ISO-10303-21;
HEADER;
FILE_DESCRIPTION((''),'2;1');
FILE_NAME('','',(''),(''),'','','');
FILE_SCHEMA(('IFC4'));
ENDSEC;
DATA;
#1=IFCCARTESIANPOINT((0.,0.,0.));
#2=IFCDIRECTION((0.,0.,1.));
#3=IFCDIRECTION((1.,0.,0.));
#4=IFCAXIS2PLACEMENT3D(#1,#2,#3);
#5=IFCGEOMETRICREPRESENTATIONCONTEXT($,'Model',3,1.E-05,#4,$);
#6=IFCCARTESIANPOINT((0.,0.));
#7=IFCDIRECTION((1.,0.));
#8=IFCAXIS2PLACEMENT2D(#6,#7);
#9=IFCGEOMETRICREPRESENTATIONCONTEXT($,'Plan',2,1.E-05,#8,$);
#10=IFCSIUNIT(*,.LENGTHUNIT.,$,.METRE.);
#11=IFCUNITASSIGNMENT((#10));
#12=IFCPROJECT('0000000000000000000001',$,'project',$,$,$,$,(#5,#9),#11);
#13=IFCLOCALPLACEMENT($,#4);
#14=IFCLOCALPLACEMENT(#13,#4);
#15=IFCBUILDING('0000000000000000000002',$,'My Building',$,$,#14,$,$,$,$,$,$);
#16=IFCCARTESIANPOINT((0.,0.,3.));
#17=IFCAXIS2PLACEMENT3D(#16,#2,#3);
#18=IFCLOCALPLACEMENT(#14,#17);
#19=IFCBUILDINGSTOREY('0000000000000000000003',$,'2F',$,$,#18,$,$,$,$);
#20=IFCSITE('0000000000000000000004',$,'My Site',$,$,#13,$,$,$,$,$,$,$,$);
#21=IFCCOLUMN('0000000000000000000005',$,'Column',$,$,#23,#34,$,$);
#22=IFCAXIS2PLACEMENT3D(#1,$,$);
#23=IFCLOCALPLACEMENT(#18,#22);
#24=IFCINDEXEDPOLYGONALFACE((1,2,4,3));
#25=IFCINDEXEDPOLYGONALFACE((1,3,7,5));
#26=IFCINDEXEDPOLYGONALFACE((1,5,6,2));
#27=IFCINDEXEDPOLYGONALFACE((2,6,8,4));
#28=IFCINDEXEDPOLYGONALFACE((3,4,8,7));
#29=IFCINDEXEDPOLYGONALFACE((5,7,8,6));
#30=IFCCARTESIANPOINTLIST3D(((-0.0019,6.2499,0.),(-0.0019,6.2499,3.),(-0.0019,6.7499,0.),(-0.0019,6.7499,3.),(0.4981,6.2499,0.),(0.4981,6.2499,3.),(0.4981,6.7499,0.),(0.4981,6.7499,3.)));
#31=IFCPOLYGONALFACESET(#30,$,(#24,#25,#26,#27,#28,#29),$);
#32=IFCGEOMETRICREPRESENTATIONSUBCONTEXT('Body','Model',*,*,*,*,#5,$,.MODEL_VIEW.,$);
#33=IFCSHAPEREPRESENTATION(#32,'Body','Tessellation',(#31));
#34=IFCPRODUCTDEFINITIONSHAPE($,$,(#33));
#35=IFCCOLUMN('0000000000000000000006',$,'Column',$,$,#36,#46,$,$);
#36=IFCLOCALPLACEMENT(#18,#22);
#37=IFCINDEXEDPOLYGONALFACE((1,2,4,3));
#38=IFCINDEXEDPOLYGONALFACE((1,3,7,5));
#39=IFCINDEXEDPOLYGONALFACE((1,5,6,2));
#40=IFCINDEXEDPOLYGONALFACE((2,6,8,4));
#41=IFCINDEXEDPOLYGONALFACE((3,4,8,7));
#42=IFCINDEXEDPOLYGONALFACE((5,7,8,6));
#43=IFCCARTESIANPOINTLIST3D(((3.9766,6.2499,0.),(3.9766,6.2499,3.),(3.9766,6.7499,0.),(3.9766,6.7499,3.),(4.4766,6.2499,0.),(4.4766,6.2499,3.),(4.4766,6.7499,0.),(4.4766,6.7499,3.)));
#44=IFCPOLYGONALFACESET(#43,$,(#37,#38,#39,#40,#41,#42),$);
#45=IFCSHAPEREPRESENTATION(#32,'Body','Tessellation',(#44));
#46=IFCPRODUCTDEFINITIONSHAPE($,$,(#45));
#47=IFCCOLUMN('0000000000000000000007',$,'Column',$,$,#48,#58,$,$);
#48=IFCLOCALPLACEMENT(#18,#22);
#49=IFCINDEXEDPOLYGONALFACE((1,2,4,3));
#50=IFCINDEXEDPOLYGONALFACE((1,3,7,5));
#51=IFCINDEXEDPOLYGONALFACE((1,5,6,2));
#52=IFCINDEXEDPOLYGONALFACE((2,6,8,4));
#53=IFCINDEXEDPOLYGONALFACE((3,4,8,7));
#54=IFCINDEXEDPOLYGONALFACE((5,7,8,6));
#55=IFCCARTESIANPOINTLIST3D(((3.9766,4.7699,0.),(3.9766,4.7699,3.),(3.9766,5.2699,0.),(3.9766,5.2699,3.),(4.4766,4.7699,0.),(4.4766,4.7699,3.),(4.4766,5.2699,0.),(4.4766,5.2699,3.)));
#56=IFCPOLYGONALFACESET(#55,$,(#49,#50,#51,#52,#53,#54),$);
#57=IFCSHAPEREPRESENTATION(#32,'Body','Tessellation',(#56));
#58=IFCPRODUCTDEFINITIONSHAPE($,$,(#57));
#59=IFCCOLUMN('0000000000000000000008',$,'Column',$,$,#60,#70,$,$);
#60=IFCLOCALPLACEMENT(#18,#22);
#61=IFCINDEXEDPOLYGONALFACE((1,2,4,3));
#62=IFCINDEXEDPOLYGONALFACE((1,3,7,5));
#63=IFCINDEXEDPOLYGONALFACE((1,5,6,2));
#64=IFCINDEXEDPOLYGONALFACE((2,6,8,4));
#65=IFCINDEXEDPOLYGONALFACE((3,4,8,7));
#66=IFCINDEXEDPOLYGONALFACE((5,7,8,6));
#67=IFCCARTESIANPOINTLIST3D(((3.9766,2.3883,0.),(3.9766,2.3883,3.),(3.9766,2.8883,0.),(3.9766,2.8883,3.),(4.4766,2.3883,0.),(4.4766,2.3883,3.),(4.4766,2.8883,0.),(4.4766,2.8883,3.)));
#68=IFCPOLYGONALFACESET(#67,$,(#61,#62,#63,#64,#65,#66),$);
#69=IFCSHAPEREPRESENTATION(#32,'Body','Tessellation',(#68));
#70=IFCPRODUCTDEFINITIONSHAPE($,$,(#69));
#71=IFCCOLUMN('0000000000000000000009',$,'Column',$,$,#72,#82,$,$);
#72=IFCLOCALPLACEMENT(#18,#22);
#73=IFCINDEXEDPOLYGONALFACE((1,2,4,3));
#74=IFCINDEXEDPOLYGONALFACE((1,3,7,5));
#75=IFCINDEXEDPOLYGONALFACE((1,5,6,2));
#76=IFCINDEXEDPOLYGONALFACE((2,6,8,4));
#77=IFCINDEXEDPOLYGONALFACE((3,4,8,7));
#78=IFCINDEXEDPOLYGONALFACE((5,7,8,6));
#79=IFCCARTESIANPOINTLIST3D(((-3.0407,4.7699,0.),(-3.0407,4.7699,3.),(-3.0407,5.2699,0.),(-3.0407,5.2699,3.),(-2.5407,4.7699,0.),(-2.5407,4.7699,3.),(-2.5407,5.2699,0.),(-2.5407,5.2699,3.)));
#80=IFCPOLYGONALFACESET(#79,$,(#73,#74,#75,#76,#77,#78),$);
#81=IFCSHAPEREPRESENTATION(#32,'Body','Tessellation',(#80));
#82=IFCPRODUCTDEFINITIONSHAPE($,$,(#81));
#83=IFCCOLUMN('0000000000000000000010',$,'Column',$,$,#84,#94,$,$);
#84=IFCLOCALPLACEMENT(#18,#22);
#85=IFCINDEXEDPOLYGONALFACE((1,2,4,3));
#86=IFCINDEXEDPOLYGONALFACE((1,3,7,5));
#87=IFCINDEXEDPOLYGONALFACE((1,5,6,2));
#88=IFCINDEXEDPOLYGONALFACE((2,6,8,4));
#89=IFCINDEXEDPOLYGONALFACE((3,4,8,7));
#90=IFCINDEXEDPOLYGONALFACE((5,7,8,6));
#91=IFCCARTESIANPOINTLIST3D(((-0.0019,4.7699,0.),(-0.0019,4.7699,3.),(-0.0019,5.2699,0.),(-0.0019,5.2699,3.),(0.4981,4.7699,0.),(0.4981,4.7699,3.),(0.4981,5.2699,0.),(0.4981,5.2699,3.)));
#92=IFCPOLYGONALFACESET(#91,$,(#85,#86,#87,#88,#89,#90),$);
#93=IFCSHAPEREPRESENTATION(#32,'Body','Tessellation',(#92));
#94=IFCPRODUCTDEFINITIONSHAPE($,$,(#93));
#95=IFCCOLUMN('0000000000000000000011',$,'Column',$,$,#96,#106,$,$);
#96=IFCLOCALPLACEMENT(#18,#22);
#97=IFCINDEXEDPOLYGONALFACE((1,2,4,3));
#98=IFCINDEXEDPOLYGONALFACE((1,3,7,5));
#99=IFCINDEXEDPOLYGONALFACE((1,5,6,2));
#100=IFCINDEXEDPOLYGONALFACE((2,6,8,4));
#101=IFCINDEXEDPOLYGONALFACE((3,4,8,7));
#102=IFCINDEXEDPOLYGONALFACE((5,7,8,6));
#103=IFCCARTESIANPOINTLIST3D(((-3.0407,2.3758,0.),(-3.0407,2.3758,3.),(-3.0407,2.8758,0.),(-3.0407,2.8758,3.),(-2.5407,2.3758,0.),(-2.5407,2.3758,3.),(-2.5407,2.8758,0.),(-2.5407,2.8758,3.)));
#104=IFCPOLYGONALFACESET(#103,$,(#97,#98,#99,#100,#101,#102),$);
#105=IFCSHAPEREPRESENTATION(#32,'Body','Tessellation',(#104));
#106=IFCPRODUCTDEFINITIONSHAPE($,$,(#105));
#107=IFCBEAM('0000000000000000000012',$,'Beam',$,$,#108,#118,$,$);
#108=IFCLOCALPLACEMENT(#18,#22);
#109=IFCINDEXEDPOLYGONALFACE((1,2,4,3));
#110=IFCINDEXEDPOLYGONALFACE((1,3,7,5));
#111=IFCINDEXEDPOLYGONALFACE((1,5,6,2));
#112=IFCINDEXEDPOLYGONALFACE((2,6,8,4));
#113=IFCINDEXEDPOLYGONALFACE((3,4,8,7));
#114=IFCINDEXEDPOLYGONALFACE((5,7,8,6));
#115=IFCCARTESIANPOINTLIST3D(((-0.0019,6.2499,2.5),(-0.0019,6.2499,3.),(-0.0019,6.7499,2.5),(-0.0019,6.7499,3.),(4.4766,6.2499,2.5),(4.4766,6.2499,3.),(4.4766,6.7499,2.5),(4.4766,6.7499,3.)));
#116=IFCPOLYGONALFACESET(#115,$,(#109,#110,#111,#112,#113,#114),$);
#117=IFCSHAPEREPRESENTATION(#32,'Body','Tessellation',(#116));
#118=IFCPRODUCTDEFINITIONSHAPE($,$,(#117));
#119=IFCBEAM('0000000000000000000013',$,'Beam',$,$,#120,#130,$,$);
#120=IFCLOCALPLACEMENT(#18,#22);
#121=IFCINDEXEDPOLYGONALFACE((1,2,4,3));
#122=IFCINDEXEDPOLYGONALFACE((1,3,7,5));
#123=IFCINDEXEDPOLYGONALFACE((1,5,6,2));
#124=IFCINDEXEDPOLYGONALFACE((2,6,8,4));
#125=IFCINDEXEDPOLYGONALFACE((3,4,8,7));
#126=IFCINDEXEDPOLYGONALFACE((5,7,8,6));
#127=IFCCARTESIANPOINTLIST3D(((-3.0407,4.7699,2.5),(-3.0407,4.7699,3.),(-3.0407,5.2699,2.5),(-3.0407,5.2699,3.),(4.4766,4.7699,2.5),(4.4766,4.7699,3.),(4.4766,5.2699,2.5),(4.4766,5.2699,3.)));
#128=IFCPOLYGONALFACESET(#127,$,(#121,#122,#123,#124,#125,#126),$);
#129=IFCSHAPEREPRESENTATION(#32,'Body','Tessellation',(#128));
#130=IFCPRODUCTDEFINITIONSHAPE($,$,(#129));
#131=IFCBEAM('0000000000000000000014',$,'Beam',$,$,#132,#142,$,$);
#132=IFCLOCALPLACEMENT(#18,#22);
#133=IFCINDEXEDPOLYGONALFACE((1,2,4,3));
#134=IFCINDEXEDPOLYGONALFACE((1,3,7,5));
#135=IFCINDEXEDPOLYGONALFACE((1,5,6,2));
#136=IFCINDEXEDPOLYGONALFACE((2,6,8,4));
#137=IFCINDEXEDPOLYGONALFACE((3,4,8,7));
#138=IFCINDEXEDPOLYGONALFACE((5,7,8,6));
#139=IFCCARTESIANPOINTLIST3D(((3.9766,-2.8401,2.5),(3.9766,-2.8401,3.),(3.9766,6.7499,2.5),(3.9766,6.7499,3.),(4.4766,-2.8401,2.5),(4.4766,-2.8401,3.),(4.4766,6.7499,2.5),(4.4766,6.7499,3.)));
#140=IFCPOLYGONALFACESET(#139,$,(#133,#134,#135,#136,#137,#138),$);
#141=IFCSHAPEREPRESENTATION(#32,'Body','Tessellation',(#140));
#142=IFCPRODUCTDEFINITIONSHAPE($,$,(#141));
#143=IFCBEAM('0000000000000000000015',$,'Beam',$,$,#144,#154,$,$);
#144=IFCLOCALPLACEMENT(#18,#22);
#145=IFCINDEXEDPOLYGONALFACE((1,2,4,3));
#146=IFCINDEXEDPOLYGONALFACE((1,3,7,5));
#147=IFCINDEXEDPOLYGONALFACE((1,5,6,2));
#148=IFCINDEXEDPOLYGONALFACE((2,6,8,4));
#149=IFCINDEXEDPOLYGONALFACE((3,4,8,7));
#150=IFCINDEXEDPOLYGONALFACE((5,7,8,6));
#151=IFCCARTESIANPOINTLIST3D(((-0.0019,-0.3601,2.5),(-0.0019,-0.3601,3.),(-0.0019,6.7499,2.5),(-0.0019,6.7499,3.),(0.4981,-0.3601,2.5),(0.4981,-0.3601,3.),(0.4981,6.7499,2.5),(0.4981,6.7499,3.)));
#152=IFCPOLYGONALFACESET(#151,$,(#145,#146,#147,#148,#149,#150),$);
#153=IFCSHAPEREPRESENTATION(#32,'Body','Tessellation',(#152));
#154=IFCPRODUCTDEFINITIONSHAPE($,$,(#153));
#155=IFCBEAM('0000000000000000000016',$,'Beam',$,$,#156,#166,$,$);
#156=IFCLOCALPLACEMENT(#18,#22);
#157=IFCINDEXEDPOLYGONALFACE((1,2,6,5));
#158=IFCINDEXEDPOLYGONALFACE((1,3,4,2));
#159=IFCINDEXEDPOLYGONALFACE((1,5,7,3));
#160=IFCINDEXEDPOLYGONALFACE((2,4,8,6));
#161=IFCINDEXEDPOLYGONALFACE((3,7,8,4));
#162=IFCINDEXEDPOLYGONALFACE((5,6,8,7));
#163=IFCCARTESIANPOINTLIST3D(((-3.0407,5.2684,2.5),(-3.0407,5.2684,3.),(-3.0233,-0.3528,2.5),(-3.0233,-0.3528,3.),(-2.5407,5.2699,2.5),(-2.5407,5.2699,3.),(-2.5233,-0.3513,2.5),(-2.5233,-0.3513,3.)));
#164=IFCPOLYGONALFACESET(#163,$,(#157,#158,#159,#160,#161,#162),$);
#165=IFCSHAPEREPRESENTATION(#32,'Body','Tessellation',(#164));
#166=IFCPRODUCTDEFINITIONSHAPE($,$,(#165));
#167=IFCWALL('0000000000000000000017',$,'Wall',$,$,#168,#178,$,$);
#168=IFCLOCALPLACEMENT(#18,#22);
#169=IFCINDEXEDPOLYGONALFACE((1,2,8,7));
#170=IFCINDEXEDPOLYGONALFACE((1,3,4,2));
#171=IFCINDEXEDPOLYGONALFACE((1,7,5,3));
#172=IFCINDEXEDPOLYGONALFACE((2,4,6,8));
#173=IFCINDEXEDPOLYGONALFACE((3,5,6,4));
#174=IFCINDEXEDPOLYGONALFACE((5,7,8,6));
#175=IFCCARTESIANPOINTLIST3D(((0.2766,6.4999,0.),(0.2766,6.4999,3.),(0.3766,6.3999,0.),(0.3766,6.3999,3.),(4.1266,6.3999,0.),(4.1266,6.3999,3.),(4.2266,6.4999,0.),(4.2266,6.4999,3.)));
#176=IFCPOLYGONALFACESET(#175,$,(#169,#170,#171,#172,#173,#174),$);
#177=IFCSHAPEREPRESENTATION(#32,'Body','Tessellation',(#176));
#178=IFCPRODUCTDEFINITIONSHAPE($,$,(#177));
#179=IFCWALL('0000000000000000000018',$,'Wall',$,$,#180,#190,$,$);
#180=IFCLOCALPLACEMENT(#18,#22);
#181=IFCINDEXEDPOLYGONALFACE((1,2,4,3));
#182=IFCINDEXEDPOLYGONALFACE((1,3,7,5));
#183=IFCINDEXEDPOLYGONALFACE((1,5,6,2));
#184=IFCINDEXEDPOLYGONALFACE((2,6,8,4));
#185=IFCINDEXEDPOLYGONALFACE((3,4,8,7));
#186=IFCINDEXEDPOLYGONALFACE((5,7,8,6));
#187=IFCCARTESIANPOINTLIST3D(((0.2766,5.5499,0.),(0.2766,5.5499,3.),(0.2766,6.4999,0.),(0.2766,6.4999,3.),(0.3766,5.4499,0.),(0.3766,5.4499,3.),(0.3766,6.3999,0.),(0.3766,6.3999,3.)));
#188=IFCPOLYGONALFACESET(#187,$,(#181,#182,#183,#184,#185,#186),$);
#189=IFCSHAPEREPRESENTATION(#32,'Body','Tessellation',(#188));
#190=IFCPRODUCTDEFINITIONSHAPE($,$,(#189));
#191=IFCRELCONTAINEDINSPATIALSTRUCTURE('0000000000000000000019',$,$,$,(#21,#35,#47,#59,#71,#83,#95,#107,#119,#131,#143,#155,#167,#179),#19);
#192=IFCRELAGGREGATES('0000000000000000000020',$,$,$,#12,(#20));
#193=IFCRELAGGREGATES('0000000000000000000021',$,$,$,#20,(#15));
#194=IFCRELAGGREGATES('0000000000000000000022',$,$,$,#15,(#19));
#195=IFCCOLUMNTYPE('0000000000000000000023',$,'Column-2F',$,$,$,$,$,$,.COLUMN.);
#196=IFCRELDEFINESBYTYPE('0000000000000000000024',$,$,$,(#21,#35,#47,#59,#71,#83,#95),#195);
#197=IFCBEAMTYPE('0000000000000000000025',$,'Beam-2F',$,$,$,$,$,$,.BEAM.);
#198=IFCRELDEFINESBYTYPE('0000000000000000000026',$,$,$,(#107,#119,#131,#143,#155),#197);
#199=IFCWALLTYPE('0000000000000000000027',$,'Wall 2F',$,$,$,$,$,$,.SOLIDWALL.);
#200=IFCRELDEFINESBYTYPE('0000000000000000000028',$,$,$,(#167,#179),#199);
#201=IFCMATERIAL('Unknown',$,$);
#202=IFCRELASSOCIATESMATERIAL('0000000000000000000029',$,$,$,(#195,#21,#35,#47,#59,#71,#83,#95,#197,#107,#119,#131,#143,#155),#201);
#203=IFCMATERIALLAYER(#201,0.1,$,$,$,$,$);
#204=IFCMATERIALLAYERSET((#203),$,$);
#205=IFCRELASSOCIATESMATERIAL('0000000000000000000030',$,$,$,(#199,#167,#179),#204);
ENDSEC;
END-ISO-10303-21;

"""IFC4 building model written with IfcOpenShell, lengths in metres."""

from ifc_helpers import new_model, si_unit, frame, origin_with_axes, origin_2d_with_axis, place, context, subcontext, project, spatial, line, indexed_curve, rectangle, outline, extrude, material, layer, layer_set, layer_usage, material_profile, profile_set, profile_usage, type_object, element, save


model = new_model("IFC4")

# Units and contexts
model_context = context("Model", 3, precision=1e-05, world=origin_with_axes())
plan_context = context("Plan", 2, precision=1e-05, world=origin_2d_with_axis())
body_context_1 = subcontext(model_context, "Body", "Model", "MODEL_VIEW")
ifc_project = project(units=[si_unit("LENGTHUNIT", "METRE")], contexts=[model_context, plan_context])

# Site, building, storey
site_placement = place(None, origin_with_axes())
site = spatial("IfcSite", under=ifc_project, at=site_placement, Name="My Site")
building_placement = place(site_placement, origin_with_axes())
building = spatial("IfcBuilding", under=site, at=building_placement, Name="My Building")
storey_placement = place(building_placement, frame((0.0, 0.0, 3.0), z_axis=(0.0, 0.0, 1.0), x_axis=(1.0, 0.0, 0.0)))
storey = spatial("IfcBuildingStorey", under=building, at=storey_placement, Name="2F")

# Columns
ifc_material = material(Name="Unknown")
ifc_material_profile_1 = material_profile(ifc_material, rectangle(XDim=0.5, YDim=0.5))
ifc_profile_set_1 = profile_set([ifc_material_profile_1])
ifc_profile_usage_1 = profile_usage(ifc_profile_set_1, cardinal=7)
column_type = type_object("IfcColumnType", Name="Column-2F", PredefinedType="COLUMN", material=ifc_profile_set_1)
column_1_placement = place(storey_placement, frame((0.4981, 6.7499, 0.0), z_axis=(0.0, 0.0, 1.0), x_axis=(1.0, 0.0, 0.0)))
element("IfcColumn", 1, at=column_1_placement, inside=storey, type_object=column_type, material=ifc_profile_usage_1, Name="Column", context=body_context_1, shape_type="SweptSolid", body=[
    extrude(rectangle(XDim=0.5, YDim=0.5), frame((-0.25, -0.25, 0.0), z_axis=(0.0, 0.0, 1.0), x_axis=(1.0, 0.0, 0.0)), (0.0, 0.0, 1.0), 3.0),
])
ifc_profile_usage_2 = profile_usage(ifc_profile_set_1, cardinal=7)
column_2_placement = place(storey_placement, frame((4.4766, 6.7499, 0.0), z_axis=(0.0, 0.0, 1.0), x_axis=(1.0, 0.0, 0.0)))
element("IfcColumn", 2, at=column_2_placement, inside=storey, type_object=column_type, material=ifc_profile_usage_2, Name="Column", context=body_context_1, shape_type="SweptSolid", body=[
    extrude(rectangle(XDim=0.5, YDim=0.5), frame((-0.25, -0.25, 0.0), z_axis=(0.0, 0.0, 1.0), x_axis=(1.0, 0.0, 0.0)), (0.0, 0.0, 1.0), 3.0),
])
ifc_profile_usage_3 = profile_usage(ifc_profile_set_1, cardinal=7)
column_3_placement = place(storey_placement, frame((4.4766, 5.2699, 0.0), z_axis=(0.0, 0.0, 1.0), x_axis=(1.0, 0.0, 0.0)))
element("IfcColumn", 3, at=column_3_placement, inside=storey, type_object=column_type, material=ifc_profile_usage_3, Name="Column", context=body_context_1, shape_type="SweptSolid", body=[
    extrude(rectangle(XDim=0.5, YDim=0.5), frame((-0.25, -0.25, 0.0), z_axis=(0.0, 0.0, 1.0), x_axis=(1.0, 0.0, 0.0)), (0.0, 0.0, 1.0), 3.0),
])
ifc_profile_usage_4 = profile_usage(ifc_profile_set_1, cardinal=7)
column_4_placement = place(storey_placement, frame((4.4766, 2.8883, 0.0), z_axis=(0.0, 0.0, 1.0), x_axis=(1.0, 0.0, 0.0)))
element("IfcColumn", 4, at=column_4_placement, inside=storey, type_object=column_type, material=ifc_profile_usage_4, Name="Column", context=body_context_1, shape_type="SweptSolid", body=[
    extrude(rectangle(XDim=0.5, YDim=0.5), frame((-0.25, -0.25, 0.0), z_axis=(0.0, 0.0, 1.0), x_axis=(1.0, 0.0, 0.0)), (0.0, 0.0, 1.0), 3.0),
])
ifc_profile_usage_5 = profile_usage(ifc_profile_set_1, cardinal=7)
column_5_placement = place(storey_placement, frame((-2.5407, 5.2699, 0.0), z_axis=(0.0, 0.0, 1.0), x_axis=(1.0, 0.0, 0.0)))
element("IfcColumn", 5, at=column_5_placement, inside=storey, type_object=column_type, material=ifc_profile_usage_5, Name="Column", context=body_context_1, shape_type="SweptSolid", body=[
    extrude(rectangle(XDim=0.5, YDim=0.5), frame((-0.25, -0.25, 0.0), z_axis=(0.0, 0.0, 1.0), x_axis=(1.0, 0.0, 0.0)), (0.0, 0.0, 1.0), 3.0),
])
ifc_profile_usage_6 = profile_usage(ifc_profile_set_1, cardinal=7)
column_6_placement = place(storey_placement, frame((0.4981, 5.2699, 0.0), z_axis=(0.0, 0.0, 1.0), x_axis=(1.0, 0.0, 0.0)))
element("IfcColumn", 6, at=column_6_placement, inside=storey, type_object=column_type, material=ifc_profile_usage_6, Name="Column", context=body_context_1, shape_type="SweptSolid", body=[
    extrude(rectangle(XDim=0.5, YDim=0.5), frame((-0.25, -0.25, 0.0), z_axis=(0.0, 0.0, 1.0), x_axis=(1.0, 0.0, 0.0)), (0.0, 0.0, 1.0), 3.0),
])
ifc_profile_usage_7 = profile_usage(ifc_profile_set_1, cardinal=7)
column_7_placement = place(storey_placement, frame((-2.5407, 2.8758, 0.0), z_axis=(0.0, 0.0, 1.0), x_axis=(1.0, 0.0, 0.0)))
element("IfcColumn", 7, at=column_7_placement, inside=storey, type_object=column_type, material=ifc_profile_usage_7, Name="Column", context=body_context_1, shape_type="SweptSolid", body=[
    extrude(rectangle(XDim=0.5, YDim=0.5), frame((-0.25, -0.25, 0.0), z_axis=(0.0, 0.0, 1.0), x_axis=(1.0, 0.0, 0.0)), (0.0, 0.0, 1.0), 3.0),
])

# Beams
ifc_material_profile_2 = material_profile(ifc_material, rectangle(XDim=0.5, YDim=0.5))
ifc_profile_set_2 = profile_set([ifc_material_profile_2])
ifc_profile_usage_8 = profile_usage(ifc_profile_set_2, cardinal=7)
beam_type = type_object("IfcBeamType", Name="Beam-2F", PredefinedType="BEAM", material=ifc_profile_set_2)
beam_1_placement = place(storey_placement, frame((-0.0019, 6.7499, 3.0), z_axis=(1.0, 0.0, 0.0), x_axis=(0.0, 1.0, 0.0)))
element("IfcBeam", 8, at=beam_1_placement, inside=storey, type_object=beam_type, material=ifc_profile_usage_8, Name="Beam", context=body_context_1, shape_type="SweptSolid", body=[
    extrude(rectangle(XDim=0.5, YDim=0.5), frame((-0.25, -0.25, 0.0), z_axis=(0.0, 0.0, 1.0), x_axis=(1.0, 0.0, 0.0)), (0.0, 0.0, 1.0), 4.4785),
])
ifc_profile_usage_9 = profile_usage(ifc_profile_set_2, cardinal=7)
beam_2_placement = place(storey_placement, frame((-3.0407, 5.2699, 3.0), z_axis=(1.0, 0.0, 0.0), x_axis=(0.0, 1.0, 0.0)))
element("IfcBeam", 9, at=beam_2_placement, inside=storey, type_object=beam_type, material=ifc_profile_usage_9, Name="Beam", context=body_context_1, shape_type="SweptSolid", body=[
    extrude(rectangle(XDim=0.5, YDim=0.5), frame((-0.25, -0.25, 0.0), z_axis=(0.0, 0.0, 1.0), x_axis=(1.0, 0.0, 0.0)), (0.0, 0.0, 1.0), 7.5173),
])
ifc_profile_usage_10 = profile_usage(ifc_profile_set_2, cardinal=7)
beam_3_placement = place(storey_placement, frame((4.4766, 6.7499, 3.0), z_axis=(0.0, -1.0, 0.0), x_axis=(1.0, 0.0, 0.0)))
element("IfcBeam", 10, at=beam_3_placement, inside=storey, type_object=beam_type, material=ifc_profile_usage_10, Name="Beam", context=body_context_1, shape_type="SweptSolid", body=[
    extrude(rectangle(XDim=0.5, YDim=0.5), frame((-0.25, -0.25, 0.0), z_axis=(0.0, 0.0, 1.0), x_axis=(1.0, 0.0, 0.0)), (0.0, 0.0, 1.0), 9.59),
])
ifc_profile_usage_11 = profile_usage(ifc_profile_set_2, cardinal=7)
beam_4_placement = place(storey_placement, frame((0.4981, 6.7499, 3.0), z_axis=(0.0, -1.0, 0.0), x_axis=(1.0, 0.0, 0.0)))
element("IfcBeam", 11, at=beam_4_placement, inside=storey, type_object=beam_type, material=ifc_profile_usage_11, Name="Beam", context=body_context_1, shape_type="SweptSolid", body=[
    extrude(rectangle(XDim=0.5, YDim=0.5), frame((-0.25, -0.25, 0.0), z_axis=(0.0, 0.0, 1.0), x_axis=(1.0, 0.0, 0.0)), (0.0, 0.0, 1.0), 7.11),
])
ifc_profile_usage_12 = profile_usage(ifc_profile_set_2, cardinal=7)
beam_5_placement = place(storey_placement, frame((-2.5407, 5.2699, 3.0), z_axis=(0.003089, -0.999995, 0.0), x_axis=(0.999995, 0.003089, 0.0)))
element("IfcBeam", 12, at=beam_5_placement, inside=storey, type_object=beam_type, material=ifc_profile_usage_12, Name="Beam", context=body_context_1, shape_type="SweptSolid", body=[
    extrude(rectangle(XDim=0.5, YDim=0.5), frame((-0.25, -0.25, 0.0), z_axis=(0.0, 0.0, 1.0), x_axis=(1.0, 0.0, 0.0)), (0.0, 0.0, 1.0), 5.6212),
])

# Walls
ifc_layer = layer(ifc_material, 0.1)
ifc_layer_set = layer_set([ifc_layer])
ifc_layer_usage_1 = layer_usage(ifc_layer_set, "AXIS2", "POSITIVE", 0.0)
wall_type = type_object("IfcWallType", Name="Wall 2F", PredefinedType="SOLIDWALL", material=ifc_layer_set)
wall_1_placement = place(storey_placement, frame((4.2266, 6.4999, 0.0), z_axis=(0.0, 0.0, 1.0), x_axis=(-1.0, 0.0, 0.0)))
element("IfcWall", 13, at=wall_1_placement, inside=storey, type_object=wall_type, material=ifc_layer_usage_1, Name="Wall", context=body_context_1, shape_type="SweptSolid", body=[
    extrude(outline(indexed_curve([(0.0, 0.0), (0.1, 0.1), (3.85, 0.1), (3.95, 0.0)], segments=[line(1, 2, 3, 4, 1)])), origin_with_axes(), (0.0, 0.0, 1.0), 3.0),
])
ifc_layer_usage_2 = layer_usage(ifc_layer_set, "AXIS2", "POSITIVE", 0.0)
wall_2_placement = place(storey_placement, frame((0.2766, 6.4999, 0.0), z_axis=(0.0, 0.0, 1.0), x_axis=(0.0, -1.0, 0.0)))
element("IfcWall", 14, at=wall_2_placement, inside=storey, type_object=wall_type, material=ifc_layer_usage_2, Name="Wall", context=body_context_1, shape_type="SweptSolid", body=[
    extrude(outline(indexed_curve([(0.0, 0.0), (0.1, 0.1), (1.05, 0.1), (0.95, 0.0)], segments=[line(1, 2, 3, 4, 1)])), origin_with_axes(), (0.0, 0.0, 1.0), 3.0),
])

save(model, "model.ifc")
